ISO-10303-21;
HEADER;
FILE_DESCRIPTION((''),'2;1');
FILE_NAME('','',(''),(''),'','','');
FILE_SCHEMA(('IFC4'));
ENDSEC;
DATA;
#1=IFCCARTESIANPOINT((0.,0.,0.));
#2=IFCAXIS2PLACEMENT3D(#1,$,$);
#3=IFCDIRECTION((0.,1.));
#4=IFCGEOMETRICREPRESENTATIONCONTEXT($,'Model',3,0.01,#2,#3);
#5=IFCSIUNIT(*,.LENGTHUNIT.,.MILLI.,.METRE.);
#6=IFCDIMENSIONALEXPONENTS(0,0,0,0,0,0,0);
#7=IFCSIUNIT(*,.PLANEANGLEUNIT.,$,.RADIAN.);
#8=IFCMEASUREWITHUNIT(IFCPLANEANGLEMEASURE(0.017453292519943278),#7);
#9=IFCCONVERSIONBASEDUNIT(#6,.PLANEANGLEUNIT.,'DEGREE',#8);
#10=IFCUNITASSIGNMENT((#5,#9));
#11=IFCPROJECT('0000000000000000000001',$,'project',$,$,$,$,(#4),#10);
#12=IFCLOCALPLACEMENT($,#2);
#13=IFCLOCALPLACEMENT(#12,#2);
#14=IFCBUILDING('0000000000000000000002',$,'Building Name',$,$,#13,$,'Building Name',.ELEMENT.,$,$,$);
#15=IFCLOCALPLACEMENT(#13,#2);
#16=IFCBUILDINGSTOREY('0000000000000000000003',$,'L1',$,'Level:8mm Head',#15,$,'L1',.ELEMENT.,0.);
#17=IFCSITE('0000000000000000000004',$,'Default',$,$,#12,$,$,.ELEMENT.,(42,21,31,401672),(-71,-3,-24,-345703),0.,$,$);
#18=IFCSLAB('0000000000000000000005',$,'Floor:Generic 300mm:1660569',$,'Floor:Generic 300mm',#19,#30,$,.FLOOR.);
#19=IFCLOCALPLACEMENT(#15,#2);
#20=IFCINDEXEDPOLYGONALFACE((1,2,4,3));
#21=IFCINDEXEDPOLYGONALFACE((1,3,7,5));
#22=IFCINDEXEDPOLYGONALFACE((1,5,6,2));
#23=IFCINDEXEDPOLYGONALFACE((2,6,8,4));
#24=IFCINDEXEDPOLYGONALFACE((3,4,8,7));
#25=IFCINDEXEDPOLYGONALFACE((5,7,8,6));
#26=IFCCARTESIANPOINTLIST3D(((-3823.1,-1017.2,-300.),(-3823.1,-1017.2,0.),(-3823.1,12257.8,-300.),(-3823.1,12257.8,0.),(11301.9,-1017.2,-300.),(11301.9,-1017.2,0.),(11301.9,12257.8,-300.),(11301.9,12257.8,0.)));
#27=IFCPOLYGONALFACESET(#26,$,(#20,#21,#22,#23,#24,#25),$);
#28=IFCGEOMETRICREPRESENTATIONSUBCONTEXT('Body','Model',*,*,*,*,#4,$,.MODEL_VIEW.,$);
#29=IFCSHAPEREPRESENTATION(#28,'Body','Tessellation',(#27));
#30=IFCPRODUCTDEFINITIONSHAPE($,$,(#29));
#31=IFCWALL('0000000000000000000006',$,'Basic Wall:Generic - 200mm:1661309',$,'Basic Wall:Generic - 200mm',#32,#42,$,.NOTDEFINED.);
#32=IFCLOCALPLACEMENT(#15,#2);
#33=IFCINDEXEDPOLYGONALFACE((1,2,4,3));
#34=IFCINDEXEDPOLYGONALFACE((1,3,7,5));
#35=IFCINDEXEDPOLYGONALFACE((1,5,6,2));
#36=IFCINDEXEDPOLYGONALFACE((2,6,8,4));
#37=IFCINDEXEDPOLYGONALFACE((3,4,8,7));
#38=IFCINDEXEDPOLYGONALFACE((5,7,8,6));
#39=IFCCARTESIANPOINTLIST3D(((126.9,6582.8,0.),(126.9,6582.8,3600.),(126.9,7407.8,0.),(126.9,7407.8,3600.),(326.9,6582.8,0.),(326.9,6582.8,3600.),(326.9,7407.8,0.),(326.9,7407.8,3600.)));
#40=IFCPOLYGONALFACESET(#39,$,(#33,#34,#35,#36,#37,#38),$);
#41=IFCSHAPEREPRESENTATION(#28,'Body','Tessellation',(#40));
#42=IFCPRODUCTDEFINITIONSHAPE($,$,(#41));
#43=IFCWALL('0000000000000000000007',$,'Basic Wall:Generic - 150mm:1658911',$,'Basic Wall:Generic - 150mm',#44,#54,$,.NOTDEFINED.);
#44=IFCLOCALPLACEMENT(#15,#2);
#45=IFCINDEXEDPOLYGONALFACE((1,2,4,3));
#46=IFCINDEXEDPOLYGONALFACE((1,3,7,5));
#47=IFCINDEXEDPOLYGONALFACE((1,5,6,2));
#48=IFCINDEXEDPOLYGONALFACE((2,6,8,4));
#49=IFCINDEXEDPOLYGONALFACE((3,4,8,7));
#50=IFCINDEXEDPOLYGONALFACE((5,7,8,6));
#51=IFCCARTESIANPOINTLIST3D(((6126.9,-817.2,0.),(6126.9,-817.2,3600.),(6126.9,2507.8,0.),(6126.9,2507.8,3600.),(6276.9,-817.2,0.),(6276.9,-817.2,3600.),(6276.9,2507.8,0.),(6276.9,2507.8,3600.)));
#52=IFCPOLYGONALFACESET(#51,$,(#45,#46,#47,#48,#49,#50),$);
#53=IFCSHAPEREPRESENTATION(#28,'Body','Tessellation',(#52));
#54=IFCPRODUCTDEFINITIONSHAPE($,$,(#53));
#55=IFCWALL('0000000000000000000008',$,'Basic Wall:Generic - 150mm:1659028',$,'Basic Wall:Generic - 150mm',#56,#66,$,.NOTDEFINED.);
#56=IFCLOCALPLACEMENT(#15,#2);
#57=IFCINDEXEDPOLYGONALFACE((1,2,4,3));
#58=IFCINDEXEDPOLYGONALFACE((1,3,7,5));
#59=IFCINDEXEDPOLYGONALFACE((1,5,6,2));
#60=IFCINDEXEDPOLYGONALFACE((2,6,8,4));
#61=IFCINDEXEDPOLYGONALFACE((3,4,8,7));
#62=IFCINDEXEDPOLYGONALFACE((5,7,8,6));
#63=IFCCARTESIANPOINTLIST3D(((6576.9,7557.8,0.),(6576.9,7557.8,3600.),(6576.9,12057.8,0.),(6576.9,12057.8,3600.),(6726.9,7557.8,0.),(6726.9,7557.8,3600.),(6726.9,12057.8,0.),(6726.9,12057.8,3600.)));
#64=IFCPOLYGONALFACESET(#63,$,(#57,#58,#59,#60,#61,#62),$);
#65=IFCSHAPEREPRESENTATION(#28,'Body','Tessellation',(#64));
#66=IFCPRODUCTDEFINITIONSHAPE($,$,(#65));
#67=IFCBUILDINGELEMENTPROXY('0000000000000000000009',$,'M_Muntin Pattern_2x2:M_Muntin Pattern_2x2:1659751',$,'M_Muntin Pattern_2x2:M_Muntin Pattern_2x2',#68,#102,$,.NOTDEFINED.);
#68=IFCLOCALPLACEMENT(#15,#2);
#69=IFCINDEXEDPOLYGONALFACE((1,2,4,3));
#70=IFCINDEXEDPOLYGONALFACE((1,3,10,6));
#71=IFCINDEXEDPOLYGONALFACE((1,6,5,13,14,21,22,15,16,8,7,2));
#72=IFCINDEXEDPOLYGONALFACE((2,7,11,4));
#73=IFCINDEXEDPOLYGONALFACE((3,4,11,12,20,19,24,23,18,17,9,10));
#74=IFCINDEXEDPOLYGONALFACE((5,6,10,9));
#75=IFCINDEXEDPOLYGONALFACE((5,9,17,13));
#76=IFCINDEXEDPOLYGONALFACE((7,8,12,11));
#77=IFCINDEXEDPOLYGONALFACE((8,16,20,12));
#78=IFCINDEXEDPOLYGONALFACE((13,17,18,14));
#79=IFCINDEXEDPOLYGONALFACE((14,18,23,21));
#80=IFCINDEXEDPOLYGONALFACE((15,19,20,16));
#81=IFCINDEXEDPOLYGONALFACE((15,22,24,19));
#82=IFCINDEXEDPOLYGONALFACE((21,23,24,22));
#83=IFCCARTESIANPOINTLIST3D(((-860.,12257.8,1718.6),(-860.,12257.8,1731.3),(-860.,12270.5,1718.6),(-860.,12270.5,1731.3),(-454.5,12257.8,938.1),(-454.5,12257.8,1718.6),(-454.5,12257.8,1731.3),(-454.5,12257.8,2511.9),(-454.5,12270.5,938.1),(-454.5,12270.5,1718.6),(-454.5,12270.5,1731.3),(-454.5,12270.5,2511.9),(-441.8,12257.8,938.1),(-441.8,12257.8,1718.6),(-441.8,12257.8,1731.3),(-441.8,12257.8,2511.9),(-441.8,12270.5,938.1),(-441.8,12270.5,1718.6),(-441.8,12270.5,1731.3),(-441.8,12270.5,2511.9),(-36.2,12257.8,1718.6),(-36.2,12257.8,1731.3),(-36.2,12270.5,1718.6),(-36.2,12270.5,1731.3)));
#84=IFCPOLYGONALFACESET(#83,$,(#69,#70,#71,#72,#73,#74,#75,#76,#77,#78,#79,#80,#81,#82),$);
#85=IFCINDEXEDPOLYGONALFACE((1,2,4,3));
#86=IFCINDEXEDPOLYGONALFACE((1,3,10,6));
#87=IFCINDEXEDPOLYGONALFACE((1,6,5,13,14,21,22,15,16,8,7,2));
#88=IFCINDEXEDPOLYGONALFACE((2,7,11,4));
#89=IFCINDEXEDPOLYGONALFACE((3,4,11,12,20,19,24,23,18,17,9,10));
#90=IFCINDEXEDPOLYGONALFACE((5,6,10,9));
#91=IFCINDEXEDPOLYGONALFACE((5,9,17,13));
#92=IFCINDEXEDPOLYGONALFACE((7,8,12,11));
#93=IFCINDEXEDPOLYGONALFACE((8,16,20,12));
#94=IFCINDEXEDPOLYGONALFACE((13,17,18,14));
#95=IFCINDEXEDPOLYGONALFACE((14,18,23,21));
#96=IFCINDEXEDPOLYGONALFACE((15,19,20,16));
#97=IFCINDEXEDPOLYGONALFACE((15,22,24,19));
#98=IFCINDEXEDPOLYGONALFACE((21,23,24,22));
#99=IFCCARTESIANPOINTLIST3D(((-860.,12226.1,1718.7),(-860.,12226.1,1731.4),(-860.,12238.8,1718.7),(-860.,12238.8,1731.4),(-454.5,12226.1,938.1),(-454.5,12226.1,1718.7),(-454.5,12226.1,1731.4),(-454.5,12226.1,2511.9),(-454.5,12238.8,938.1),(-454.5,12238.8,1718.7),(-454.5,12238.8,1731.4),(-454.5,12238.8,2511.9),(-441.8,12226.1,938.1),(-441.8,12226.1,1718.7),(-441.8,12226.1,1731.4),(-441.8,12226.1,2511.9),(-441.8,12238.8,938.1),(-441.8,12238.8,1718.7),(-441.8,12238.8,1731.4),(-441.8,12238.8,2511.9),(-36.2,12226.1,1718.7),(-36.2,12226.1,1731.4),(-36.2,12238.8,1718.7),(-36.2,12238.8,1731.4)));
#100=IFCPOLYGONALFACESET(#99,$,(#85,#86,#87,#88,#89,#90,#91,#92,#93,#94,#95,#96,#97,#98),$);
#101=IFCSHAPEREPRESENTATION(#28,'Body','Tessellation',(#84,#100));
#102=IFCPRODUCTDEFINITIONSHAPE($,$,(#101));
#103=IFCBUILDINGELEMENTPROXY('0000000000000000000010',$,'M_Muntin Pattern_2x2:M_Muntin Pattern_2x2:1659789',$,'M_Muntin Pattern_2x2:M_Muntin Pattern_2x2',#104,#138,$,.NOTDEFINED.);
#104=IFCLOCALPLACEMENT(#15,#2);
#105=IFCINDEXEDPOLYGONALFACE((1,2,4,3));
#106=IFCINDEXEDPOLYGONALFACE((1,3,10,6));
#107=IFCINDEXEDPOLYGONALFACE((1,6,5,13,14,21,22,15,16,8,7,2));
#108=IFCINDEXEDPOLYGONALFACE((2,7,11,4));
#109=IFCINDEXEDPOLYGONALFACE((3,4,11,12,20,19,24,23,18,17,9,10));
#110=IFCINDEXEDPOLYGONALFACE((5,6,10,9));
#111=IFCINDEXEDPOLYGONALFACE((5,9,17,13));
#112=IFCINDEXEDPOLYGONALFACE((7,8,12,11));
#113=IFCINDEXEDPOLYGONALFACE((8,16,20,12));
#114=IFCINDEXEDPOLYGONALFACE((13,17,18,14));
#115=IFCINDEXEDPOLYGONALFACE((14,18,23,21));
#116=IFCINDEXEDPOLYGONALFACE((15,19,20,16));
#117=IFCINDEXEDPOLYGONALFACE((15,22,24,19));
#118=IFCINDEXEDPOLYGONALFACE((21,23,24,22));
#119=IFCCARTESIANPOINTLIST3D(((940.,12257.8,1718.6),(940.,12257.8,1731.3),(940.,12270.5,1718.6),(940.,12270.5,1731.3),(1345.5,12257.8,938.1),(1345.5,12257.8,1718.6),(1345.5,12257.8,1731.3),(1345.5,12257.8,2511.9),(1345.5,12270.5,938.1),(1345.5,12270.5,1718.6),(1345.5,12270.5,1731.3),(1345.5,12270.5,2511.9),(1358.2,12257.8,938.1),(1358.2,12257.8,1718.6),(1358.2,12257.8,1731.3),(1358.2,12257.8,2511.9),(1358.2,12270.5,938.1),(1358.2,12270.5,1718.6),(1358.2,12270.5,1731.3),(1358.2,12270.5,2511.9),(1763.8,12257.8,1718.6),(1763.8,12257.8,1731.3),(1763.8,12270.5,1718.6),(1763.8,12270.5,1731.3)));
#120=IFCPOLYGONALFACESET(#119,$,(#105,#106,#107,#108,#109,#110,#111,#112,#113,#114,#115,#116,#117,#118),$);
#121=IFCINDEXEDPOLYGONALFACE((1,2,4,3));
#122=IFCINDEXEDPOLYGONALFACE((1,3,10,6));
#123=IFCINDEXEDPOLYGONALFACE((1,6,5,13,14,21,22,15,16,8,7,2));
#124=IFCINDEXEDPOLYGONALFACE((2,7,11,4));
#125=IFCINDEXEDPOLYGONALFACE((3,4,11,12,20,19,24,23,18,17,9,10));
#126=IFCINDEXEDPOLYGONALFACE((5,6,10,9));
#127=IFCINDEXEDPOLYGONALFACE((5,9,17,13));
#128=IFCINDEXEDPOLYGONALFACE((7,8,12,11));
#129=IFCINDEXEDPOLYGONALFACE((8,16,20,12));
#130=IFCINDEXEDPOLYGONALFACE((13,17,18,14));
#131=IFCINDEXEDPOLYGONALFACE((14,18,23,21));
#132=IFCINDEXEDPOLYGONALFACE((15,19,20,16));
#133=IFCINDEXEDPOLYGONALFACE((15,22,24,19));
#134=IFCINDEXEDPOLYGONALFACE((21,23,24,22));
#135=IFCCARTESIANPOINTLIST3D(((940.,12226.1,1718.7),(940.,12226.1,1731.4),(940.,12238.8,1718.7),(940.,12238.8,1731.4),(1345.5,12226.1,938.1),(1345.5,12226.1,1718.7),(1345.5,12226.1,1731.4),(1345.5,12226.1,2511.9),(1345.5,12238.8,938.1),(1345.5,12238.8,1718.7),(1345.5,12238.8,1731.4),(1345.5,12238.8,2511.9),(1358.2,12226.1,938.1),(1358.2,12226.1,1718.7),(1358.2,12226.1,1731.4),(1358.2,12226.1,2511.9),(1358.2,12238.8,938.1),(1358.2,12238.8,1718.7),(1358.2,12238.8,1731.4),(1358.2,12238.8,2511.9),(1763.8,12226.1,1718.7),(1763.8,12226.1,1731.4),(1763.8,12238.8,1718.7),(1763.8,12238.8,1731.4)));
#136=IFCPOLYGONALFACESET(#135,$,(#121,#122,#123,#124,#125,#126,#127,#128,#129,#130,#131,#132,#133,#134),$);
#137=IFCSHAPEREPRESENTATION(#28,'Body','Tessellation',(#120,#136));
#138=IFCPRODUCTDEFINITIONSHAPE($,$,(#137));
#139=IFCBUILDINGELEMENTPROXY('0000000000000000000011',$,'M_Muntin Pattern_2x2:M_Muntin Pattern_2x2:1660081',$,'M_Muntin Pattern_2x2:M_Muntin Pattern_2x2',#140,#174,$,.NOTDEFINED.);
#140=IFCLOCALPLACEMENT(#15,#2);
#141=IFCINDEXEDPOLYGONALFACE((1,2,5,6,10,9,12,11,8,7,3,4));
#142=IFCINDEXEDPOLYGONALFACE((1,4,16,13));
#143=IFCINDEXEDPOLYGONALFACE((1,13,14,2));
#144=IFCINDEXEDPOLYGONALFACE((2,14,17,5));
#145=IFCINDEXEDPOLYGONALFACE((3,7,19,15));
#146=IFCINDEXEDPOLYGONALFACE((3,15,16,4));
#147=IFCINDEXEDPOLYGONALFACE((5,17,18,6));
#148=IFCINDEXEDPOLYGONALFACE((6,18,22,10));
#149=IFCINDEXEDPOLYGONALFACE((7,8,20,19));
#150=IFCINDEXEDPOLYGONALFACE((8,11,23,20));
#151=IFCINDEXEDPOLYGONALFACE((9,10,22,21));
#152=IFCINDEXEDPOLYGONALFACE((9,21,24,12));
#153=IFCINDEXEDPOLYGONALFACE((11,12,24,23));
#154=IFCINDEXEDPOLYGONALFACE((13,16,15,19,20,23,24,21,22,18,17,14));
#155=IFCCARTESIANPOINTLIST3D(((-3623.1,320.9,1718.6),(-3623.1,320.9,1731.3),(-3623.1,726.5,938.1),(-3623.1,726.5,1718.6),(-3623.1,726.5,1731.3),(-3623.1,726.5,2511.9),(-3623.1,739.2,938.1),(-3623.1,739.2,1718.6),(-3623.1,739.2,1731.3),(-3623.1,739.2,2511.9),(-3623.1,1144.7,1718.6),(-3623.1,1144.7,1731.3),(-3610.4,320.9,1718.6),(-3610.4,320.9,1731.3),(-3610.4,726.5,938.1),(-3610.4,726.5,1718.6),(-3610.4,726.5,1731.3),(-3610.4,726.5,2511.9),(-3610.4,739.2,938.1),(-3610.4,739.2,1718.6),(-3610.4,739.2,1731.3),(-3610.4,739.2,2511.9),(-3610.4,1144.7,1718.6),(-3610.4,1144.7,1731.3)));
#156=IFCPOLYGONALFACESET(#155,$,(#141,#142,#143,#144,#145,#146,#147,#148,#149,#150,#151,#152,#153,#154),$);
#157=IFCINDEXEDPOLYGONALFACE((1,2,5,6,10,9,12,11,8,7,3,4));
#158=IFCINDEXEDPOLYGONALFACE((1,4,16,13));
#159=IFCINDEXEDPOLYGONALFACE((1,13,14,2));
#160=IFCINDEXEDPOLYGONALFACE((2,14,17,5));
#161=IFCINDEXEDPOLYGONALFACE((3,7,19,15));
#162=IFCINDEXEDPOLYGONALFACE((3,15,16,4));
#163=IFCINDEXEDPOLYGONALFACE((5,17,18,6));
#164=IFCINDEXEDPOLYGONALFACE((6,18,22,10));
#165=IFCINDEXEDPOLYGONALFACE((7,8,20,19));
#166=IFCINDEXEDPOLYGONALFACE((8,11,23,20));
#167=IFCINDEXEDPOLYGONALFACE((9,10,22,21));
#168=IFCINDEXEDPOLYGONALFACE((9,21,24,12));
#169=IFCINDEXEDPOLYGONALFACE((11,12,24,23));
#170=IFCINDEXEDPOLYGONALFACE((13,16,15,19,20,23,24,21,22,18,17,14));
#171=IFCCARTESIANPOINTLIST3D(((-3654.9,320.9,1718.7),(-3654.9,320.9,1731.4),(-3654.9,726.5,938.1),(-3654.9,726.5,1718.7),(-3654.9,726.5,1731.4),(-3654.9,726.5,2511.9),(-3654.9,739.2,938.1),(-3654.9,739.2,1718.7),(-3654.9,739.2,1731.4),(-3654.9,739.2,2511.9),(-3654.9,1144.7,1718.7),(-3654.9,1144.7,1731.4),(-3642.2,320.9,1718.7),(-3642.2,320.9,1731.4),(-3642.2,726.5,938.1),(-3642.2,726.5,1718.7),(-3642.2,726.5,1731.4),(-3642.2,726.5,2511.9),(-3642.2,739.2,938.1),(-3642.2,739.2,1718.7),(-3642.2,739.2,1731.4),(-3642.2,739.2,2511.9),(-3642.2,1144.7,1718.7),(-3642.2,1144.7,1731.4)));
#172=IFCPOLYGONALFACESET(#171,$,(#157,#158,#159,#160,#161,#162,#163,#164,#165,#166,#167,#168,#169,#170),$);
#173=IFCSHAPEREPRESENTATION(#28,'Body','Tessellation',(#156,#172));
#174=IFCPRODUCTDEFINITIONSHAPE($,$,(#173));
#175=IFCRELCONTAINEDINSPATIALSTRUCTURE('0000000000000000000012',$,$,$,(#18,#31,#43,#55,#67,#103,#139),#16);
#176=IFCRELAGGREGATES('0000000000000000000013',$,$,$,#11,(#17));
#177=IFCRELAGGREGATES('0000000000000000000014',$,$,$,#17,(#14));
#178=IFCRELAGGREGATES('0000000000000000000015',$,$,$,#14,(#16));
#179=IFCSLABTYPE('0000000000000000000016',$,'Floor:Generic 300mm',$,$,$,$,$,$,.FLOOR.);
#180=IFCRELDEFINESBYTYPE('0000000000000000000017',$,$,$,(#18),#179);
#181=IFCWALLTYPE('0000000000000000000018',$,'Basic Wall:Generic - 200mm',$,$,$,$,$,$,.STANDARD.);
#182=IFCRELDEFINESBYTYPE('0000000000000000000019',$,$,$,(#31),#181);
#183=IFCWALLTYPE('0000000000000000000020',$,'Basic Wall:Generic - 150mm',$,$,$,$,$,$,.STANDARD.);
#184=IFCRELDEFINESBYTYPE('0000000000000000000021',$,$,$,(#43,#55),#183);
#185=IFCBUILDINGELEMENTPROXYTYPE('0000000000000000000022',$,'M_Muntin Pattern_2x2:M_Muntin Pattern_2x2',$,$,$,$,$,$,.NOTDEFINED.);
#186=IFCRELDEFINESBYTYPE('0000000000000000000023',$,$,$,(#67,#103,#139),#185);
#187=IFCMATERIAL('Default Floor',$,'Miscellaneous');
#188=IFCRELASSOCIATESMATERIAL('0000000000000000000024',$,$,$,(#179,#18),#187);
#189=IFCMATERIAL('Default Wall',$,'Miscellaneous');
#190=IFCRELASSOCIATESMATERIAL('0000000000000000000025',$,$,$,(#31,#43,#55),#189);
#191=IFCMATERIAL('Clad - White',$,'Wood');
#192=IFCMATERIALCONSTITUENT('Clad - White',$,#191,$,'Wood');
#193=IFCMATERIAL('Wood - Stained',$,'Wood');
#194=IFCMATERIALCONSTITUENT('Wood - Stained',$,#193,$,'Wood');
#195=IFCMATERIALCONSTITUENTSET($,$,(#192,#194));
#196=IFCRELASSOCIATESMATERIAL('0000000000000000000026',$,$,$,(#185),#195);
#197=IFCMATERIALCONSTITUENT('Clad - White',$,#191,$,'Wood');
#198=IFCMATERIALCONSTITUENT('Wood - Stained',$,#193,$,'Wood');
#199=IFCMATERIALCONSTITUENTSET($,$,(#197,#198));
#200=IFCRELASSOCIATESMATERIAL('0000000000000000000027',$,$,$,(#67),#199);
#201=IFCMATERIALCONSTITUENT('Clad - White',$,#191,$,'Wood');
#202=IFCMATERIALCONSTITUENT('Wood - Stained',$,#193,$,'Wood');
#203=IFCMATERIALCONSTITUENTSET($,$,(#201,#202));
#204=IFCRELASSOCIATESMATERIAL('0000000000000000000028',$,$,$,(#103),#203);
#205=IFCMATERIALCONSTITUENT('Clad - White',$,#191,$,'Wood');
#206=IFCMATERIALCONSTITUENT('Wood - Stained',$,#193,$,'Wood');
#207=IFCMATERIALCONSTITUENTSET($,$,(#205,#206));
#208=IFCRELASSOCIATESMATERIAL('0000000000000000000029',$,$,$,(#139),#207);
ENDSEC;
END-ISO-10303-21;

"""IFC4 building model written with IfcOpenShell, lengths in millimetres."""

from ifc_helpers import new_model, entity, si_unit, converted_unit, direction, frame, origin, place, context, subcontext, project, spatial, indexed_curve, outline, extrude, source, transform, mapped, material, constituent, constituent_set, type_object, type_shapes, element, save


model = new_model("IFC4")

# Units and contexts
model_context = context("Model", 3, precision=0.01, world=origin(), true_north=direction((0.0, 1.0)))
body_context = subcontext(model_context, "Body", "Model", "MODEL_VIEW")
ifc_project = project(units=[si_unit("LENGTHUNIT", "METRE", prefix="MILLI"), converted_unit("PLANEANGLEUNIT", "DEGREE", entity("IfcPlaneAngleMeasure", 0.017453292519943278), si_unit("PLANEANGLEUNIT", "RADIAN"), dimensions=[0, 0, 0, 0, 0, 0, 0])], contexts=[model_context])

# Site, building, storey
site_placement = place(None, origin())
site = spatial("IfcSite", under=ifc_project, at=site_placement, Name="Default", CompositionType="ELEMENT", RefLatitude=(42, 21, 31, 401672), RefLongitude=(-71, -3, -24, -345703), RefElevation=0.0)
building_placement = place(site_placement, origin())
building = spatial("IfcBuilding", under=site, at=building_placement, Name="Building Name", LongName="Building Name", CompositionType="ELEMENT")
storey_placement = place(building_placement, origin())
storey = spatial("IfcBuildingStorey", under=building, at=storey_placement, Name="L1", ObjectType="Level:8mm Head", LongName="L1", CompositionType="ELEMENT", Elevation=0.0)

# Slab
ifc_material_1 = material(Name="Default Floor", Category="Miscellaneous")
slab_type = type_object("IfcSlabType", Name="Floor:Generic 300mm", PredefinedType="FLOOR", material=ifc_material_1)
slab_placement = place(storey_placement, origin())
element("IfcSlab", 1, at=slab_placement, inside=storey, type_object=slab_type, material=ifc_material_1, Name="Floor:Generic 300mm:1660569", ObjectType="Floor:Generic 300mm", PredefinedType="FLOOR", context=body_context, shape_type="SweptSolid", body=[
    extrude(outline(indexed_curve([(-6637.5, -7562.5), (6637.5, -7562.5), (6637.5, 7562.5), (-6637.5, 7562.5), (-6637.5, -7562.5)], self_intersect=False)), frame((3739.4, 5620.3, 0.0), z_axis=(0.0, 0.0, -1.0), x_axis=(0.0, 1.0, 0.0)), (0.0, 0.0, 1.0), 300.0),
])

# Walls
ifc_material_2 = material(Name="Default Wall", Category="Miscellaneous")
wall_type_1 = type_object("IfcWallType", Name="Basic Wall:Generic - 200mm", PredefinedType="STANDARD")
wall_1_placement = place(storey_placement, frame((226.9, 7407.8, 0.0), z_axis=(0.0, 0.0, 1.0), x_axis=(0.0, -1.0, 0.0)))
element("IfcWall", 2, at=wall_1_placement, inside=storey, type_object=wall_type_1, material=ifc_material_2, Name="Basic Wall:Generic - 200mm:1661309", ObjectType="Basic Wall:Generic - 200mm", PredefinedType="NOTDEFINED", context=body_context, shape_type="SweptSolid", body=[
    extrude(outline(indexed_curve([(825.0, 100.0), (0.0, 100.0), (0.0, -100.0), (825.0, -100.0), (825.0, 100.0)], self_intersect=False)), origin(), (0.0, 0.0, 1.0), 3600.0),
])
wall_type_2 = type_object("IfcWallType", Name="Basic Wall:Generic - 150mm", PredefinedType="STANDARD")
wall_2_placement = place(storey_placement, frame((6201.9, 2507.8, 0.0), z_axis=(0.0, 0.0, 1.0), x_axis=(0.0, -1.0, 0.0)))
element("IfcWall", 3, at=wall_2_placement, inside=storey, type_object=wall_type_2, material=ifc_material_2, Name="Basic Wall:Generic - 150mm:1658911", ObjectType="Basic Wall:Generic - 150mm", PredefinedType="NOTDEFINED", context=body_context, shape_type="SweptSolid", body=[
    extrude(outline(indexed_curve([(3325.0, 75.0), (0.0, 75.0), (0.0, -75.0), (3325.0, -75.0), (3325.0, 75.0)], self_intersect=False)), origin(), (0.0, 0.0, 1.0), 3600.0),
])
wall_3_placement = place(storey_placement, frame((6651.9, 7557.8, 0.0), z_axis=(0.0, 0.0, 1.0), x_axis=(0.0, 1.0, 0.0)))
element("IfcWall", 4, at=wall_3_placement, inside=storey, type_object=wall_type_2, material=ifc_material_2, Name="Basic Wall:Generic - 150mm:1659028", ObjectType="Basic Wall:Generic - 150mm", PredefinedType="NOTDEFINED", context=body_context, shape_type="SweptSolid", body=[
    extrude(outline(indexed_curve([(4500.0, 75.0), (0.0, 75.0), (0.0, -75.0), (4500.0, -75.0), (4500.0, 75.0)], self_intersect=False)), origin(), (0.0, 0.0, 1.0), 3600.0),
])

# Building element proxies
ifc_material_3 = material(Name="Clad - White", Category="Wood")
ifc_constituent_1 = constituent(ifc_material_3, Name="Clad - White", Category="Wood")
ifc_material_4 = material(Name="Wood - Stained", Category="Wood")
ifc_constituent_2 = constituent(ifc_material_4, Name="Wood - Stained", Category="Wood")
ifc_constituent_set_1 = constituent_set(constituents=[ifc_constituent_1, ifc_constituent_2])
ifc_constituent_3 = constituent(ifc_material_3, Name="Clad - White", Category="Wood")
ifc_constituent_4 = constituent(ifc_material_4, Name="Wood - Stained", Category="Wood")
ifc_constituent_set_2 = constituent_set(constituents=[ifc_constituent_3, ifc_constituent_4])
building_element_proxy_type_1 = type_object("IfcBuildingElementProxyType", Name="M_Muntin Pattern_2x2:M_Muntin Pattern_2x2", PredefinedType="NOTDEFINED", material=ifc_constituent_set_2)
shared_shape_1 = source(origin(), body_context, "Body", "SweptSolid", [
    extrude(outline(indexed_curve([(6.4, -6.4), (786.9, -6.4), (786.9, 6.3), (6.4, 6.3), (6.4, 411.9), (-6.3, 411.9), (-6.3, 6.3), (-786.9, 6.3), (-786.9, -6.4), (-6.3, -6.4), (-6.3, -411.9), (6.4, -411.9), (6.4, -6.4)], self_intersect=False)), frame((0.0, -22.2, 786.9), z_axis=(0.0, 1.0, 0.0), x_axis=(0.0, 0.0, 1.0)), (0.0, 0.0, 1.0), 12.7),
    extrude(outline(indexed_curve([(6.4, -6.4), (786.9, -6.4), (786.9, 6.3), (6.4, 6.3), (6.4, 411.9), (-6.3, 411.9), (-6.3, 6.3), (-786.9, 6.3), (-786.9, -6.4), (-6.3, -6.4), (-6.3, -411.9), (6.4, -411.9), (6.4, -6.4)], self_intersect=False)), frame((0.0, 9.5, 786.9), z_axis=(0.0, 1.0, 0.0), x_axis=(0.0, 0.0, 1.0)), (0.0, 0.0, 1.0), 12.7),
])
type_shapes(building_element_proxy_type_1, [shared_shape_1])
proxy_1_placement = place(storey_placement, frame((-448.1, 12248.3, 938.1), z_axis=(0.0, 0.0, 1.0), x_axis=(-1.0, 0.0, 0.0)))
element("IfcBuildingElementProxy", 5, at=proxy_1_placement, inside=storey, type_object=building_element_proxy_type_1, material=ifc_constituent_set_1, Name="M_Muntin Pattern_2x2:M_Muntin Pattern_2x2:1659751", ObjectType="M_Muntin Pattern_2x2:M_Muntin Pattern_2x2", PredefinedType="NOTDEFINED", context=body_context, shape_type="MappedRepresentation", body=[
    mapped(shared_shape_1, transform((0.0, 0.0, 0.0), scale=1.0)),
])
ifc_constituent_5 = constituent(ifc_material_3, Name="Clad - White", Category="Wood")
ifc_constituent_6 = constituent(ifc_material_4, Name="Wood - Stained", Category="Wood")
ifc_constituent_set_3 = constituent_set(constituents=[ifc_constituent_5, ifc_constituent_6])
proxy_2_placement = place(storey_placement, frame((1351.9, 12248.3, 938.1), z_axis=(0.0, 0.0, 1.0), x_axis=(-1.0, 0.0, 0.0)))
element("IfcBuildingElementProxy", 6, at=proxy_2_placement, inside=storey, type_object=building_element_proxy_type_1, material=ifc_constituent_set_3, Name="M_Muntin Pattern_2x2:M_Muntin Pattern_2x2:1659789", ObjectType="M_Muntin Pattern_2x2:M_Muntin Pattern_2x2", PredefinedType="NOTDEFINED", context=body_context, shape_type="MappedRepresentation", body=[
    mapped(shared_shape_1, transform((0.0, 0.0, 0.0), scale=1.0)),
])
ifc_constituent_7 = constituent(ifc_material_3, Name="Clad - White", Category="Wood")
ifc_constituent_8 = constituent(ifc_material_4, Name="Wood - Stained", Category="Wood")
ifc_constituent_set_4 = constituent_set(constituents=[ifc_constituent_7, ifc_constituent_8])
proxy_3_placement = place(storey_placement, frame((-3632.6, 732.8, 938.1), z_axis=(0.0, 0.0, 1.0), x_axis=(0.0, 1.0, 0.0)))
element("IfcBuildingElementProxy", 7, at=proxy_3_placement, inside=storey, type_object=building_element_proxy_type_1, material=ifc_constituent_set_4, Name="M_Muntin Pattern_2x2:M_Muntin Pattern_2x2:1660081", ObjectType="M_Muntin Pattern_2x2:M_Muntin Pattern_2x2", PredefinedType="NOTDEFINED", context=body_context, shape_type="MappedRepresentation", body=[
    mapped(shared_shape_1, transform((0.0, 0.0, 0.0), scale=1.0)),
])

save(model, "model.ifc")
